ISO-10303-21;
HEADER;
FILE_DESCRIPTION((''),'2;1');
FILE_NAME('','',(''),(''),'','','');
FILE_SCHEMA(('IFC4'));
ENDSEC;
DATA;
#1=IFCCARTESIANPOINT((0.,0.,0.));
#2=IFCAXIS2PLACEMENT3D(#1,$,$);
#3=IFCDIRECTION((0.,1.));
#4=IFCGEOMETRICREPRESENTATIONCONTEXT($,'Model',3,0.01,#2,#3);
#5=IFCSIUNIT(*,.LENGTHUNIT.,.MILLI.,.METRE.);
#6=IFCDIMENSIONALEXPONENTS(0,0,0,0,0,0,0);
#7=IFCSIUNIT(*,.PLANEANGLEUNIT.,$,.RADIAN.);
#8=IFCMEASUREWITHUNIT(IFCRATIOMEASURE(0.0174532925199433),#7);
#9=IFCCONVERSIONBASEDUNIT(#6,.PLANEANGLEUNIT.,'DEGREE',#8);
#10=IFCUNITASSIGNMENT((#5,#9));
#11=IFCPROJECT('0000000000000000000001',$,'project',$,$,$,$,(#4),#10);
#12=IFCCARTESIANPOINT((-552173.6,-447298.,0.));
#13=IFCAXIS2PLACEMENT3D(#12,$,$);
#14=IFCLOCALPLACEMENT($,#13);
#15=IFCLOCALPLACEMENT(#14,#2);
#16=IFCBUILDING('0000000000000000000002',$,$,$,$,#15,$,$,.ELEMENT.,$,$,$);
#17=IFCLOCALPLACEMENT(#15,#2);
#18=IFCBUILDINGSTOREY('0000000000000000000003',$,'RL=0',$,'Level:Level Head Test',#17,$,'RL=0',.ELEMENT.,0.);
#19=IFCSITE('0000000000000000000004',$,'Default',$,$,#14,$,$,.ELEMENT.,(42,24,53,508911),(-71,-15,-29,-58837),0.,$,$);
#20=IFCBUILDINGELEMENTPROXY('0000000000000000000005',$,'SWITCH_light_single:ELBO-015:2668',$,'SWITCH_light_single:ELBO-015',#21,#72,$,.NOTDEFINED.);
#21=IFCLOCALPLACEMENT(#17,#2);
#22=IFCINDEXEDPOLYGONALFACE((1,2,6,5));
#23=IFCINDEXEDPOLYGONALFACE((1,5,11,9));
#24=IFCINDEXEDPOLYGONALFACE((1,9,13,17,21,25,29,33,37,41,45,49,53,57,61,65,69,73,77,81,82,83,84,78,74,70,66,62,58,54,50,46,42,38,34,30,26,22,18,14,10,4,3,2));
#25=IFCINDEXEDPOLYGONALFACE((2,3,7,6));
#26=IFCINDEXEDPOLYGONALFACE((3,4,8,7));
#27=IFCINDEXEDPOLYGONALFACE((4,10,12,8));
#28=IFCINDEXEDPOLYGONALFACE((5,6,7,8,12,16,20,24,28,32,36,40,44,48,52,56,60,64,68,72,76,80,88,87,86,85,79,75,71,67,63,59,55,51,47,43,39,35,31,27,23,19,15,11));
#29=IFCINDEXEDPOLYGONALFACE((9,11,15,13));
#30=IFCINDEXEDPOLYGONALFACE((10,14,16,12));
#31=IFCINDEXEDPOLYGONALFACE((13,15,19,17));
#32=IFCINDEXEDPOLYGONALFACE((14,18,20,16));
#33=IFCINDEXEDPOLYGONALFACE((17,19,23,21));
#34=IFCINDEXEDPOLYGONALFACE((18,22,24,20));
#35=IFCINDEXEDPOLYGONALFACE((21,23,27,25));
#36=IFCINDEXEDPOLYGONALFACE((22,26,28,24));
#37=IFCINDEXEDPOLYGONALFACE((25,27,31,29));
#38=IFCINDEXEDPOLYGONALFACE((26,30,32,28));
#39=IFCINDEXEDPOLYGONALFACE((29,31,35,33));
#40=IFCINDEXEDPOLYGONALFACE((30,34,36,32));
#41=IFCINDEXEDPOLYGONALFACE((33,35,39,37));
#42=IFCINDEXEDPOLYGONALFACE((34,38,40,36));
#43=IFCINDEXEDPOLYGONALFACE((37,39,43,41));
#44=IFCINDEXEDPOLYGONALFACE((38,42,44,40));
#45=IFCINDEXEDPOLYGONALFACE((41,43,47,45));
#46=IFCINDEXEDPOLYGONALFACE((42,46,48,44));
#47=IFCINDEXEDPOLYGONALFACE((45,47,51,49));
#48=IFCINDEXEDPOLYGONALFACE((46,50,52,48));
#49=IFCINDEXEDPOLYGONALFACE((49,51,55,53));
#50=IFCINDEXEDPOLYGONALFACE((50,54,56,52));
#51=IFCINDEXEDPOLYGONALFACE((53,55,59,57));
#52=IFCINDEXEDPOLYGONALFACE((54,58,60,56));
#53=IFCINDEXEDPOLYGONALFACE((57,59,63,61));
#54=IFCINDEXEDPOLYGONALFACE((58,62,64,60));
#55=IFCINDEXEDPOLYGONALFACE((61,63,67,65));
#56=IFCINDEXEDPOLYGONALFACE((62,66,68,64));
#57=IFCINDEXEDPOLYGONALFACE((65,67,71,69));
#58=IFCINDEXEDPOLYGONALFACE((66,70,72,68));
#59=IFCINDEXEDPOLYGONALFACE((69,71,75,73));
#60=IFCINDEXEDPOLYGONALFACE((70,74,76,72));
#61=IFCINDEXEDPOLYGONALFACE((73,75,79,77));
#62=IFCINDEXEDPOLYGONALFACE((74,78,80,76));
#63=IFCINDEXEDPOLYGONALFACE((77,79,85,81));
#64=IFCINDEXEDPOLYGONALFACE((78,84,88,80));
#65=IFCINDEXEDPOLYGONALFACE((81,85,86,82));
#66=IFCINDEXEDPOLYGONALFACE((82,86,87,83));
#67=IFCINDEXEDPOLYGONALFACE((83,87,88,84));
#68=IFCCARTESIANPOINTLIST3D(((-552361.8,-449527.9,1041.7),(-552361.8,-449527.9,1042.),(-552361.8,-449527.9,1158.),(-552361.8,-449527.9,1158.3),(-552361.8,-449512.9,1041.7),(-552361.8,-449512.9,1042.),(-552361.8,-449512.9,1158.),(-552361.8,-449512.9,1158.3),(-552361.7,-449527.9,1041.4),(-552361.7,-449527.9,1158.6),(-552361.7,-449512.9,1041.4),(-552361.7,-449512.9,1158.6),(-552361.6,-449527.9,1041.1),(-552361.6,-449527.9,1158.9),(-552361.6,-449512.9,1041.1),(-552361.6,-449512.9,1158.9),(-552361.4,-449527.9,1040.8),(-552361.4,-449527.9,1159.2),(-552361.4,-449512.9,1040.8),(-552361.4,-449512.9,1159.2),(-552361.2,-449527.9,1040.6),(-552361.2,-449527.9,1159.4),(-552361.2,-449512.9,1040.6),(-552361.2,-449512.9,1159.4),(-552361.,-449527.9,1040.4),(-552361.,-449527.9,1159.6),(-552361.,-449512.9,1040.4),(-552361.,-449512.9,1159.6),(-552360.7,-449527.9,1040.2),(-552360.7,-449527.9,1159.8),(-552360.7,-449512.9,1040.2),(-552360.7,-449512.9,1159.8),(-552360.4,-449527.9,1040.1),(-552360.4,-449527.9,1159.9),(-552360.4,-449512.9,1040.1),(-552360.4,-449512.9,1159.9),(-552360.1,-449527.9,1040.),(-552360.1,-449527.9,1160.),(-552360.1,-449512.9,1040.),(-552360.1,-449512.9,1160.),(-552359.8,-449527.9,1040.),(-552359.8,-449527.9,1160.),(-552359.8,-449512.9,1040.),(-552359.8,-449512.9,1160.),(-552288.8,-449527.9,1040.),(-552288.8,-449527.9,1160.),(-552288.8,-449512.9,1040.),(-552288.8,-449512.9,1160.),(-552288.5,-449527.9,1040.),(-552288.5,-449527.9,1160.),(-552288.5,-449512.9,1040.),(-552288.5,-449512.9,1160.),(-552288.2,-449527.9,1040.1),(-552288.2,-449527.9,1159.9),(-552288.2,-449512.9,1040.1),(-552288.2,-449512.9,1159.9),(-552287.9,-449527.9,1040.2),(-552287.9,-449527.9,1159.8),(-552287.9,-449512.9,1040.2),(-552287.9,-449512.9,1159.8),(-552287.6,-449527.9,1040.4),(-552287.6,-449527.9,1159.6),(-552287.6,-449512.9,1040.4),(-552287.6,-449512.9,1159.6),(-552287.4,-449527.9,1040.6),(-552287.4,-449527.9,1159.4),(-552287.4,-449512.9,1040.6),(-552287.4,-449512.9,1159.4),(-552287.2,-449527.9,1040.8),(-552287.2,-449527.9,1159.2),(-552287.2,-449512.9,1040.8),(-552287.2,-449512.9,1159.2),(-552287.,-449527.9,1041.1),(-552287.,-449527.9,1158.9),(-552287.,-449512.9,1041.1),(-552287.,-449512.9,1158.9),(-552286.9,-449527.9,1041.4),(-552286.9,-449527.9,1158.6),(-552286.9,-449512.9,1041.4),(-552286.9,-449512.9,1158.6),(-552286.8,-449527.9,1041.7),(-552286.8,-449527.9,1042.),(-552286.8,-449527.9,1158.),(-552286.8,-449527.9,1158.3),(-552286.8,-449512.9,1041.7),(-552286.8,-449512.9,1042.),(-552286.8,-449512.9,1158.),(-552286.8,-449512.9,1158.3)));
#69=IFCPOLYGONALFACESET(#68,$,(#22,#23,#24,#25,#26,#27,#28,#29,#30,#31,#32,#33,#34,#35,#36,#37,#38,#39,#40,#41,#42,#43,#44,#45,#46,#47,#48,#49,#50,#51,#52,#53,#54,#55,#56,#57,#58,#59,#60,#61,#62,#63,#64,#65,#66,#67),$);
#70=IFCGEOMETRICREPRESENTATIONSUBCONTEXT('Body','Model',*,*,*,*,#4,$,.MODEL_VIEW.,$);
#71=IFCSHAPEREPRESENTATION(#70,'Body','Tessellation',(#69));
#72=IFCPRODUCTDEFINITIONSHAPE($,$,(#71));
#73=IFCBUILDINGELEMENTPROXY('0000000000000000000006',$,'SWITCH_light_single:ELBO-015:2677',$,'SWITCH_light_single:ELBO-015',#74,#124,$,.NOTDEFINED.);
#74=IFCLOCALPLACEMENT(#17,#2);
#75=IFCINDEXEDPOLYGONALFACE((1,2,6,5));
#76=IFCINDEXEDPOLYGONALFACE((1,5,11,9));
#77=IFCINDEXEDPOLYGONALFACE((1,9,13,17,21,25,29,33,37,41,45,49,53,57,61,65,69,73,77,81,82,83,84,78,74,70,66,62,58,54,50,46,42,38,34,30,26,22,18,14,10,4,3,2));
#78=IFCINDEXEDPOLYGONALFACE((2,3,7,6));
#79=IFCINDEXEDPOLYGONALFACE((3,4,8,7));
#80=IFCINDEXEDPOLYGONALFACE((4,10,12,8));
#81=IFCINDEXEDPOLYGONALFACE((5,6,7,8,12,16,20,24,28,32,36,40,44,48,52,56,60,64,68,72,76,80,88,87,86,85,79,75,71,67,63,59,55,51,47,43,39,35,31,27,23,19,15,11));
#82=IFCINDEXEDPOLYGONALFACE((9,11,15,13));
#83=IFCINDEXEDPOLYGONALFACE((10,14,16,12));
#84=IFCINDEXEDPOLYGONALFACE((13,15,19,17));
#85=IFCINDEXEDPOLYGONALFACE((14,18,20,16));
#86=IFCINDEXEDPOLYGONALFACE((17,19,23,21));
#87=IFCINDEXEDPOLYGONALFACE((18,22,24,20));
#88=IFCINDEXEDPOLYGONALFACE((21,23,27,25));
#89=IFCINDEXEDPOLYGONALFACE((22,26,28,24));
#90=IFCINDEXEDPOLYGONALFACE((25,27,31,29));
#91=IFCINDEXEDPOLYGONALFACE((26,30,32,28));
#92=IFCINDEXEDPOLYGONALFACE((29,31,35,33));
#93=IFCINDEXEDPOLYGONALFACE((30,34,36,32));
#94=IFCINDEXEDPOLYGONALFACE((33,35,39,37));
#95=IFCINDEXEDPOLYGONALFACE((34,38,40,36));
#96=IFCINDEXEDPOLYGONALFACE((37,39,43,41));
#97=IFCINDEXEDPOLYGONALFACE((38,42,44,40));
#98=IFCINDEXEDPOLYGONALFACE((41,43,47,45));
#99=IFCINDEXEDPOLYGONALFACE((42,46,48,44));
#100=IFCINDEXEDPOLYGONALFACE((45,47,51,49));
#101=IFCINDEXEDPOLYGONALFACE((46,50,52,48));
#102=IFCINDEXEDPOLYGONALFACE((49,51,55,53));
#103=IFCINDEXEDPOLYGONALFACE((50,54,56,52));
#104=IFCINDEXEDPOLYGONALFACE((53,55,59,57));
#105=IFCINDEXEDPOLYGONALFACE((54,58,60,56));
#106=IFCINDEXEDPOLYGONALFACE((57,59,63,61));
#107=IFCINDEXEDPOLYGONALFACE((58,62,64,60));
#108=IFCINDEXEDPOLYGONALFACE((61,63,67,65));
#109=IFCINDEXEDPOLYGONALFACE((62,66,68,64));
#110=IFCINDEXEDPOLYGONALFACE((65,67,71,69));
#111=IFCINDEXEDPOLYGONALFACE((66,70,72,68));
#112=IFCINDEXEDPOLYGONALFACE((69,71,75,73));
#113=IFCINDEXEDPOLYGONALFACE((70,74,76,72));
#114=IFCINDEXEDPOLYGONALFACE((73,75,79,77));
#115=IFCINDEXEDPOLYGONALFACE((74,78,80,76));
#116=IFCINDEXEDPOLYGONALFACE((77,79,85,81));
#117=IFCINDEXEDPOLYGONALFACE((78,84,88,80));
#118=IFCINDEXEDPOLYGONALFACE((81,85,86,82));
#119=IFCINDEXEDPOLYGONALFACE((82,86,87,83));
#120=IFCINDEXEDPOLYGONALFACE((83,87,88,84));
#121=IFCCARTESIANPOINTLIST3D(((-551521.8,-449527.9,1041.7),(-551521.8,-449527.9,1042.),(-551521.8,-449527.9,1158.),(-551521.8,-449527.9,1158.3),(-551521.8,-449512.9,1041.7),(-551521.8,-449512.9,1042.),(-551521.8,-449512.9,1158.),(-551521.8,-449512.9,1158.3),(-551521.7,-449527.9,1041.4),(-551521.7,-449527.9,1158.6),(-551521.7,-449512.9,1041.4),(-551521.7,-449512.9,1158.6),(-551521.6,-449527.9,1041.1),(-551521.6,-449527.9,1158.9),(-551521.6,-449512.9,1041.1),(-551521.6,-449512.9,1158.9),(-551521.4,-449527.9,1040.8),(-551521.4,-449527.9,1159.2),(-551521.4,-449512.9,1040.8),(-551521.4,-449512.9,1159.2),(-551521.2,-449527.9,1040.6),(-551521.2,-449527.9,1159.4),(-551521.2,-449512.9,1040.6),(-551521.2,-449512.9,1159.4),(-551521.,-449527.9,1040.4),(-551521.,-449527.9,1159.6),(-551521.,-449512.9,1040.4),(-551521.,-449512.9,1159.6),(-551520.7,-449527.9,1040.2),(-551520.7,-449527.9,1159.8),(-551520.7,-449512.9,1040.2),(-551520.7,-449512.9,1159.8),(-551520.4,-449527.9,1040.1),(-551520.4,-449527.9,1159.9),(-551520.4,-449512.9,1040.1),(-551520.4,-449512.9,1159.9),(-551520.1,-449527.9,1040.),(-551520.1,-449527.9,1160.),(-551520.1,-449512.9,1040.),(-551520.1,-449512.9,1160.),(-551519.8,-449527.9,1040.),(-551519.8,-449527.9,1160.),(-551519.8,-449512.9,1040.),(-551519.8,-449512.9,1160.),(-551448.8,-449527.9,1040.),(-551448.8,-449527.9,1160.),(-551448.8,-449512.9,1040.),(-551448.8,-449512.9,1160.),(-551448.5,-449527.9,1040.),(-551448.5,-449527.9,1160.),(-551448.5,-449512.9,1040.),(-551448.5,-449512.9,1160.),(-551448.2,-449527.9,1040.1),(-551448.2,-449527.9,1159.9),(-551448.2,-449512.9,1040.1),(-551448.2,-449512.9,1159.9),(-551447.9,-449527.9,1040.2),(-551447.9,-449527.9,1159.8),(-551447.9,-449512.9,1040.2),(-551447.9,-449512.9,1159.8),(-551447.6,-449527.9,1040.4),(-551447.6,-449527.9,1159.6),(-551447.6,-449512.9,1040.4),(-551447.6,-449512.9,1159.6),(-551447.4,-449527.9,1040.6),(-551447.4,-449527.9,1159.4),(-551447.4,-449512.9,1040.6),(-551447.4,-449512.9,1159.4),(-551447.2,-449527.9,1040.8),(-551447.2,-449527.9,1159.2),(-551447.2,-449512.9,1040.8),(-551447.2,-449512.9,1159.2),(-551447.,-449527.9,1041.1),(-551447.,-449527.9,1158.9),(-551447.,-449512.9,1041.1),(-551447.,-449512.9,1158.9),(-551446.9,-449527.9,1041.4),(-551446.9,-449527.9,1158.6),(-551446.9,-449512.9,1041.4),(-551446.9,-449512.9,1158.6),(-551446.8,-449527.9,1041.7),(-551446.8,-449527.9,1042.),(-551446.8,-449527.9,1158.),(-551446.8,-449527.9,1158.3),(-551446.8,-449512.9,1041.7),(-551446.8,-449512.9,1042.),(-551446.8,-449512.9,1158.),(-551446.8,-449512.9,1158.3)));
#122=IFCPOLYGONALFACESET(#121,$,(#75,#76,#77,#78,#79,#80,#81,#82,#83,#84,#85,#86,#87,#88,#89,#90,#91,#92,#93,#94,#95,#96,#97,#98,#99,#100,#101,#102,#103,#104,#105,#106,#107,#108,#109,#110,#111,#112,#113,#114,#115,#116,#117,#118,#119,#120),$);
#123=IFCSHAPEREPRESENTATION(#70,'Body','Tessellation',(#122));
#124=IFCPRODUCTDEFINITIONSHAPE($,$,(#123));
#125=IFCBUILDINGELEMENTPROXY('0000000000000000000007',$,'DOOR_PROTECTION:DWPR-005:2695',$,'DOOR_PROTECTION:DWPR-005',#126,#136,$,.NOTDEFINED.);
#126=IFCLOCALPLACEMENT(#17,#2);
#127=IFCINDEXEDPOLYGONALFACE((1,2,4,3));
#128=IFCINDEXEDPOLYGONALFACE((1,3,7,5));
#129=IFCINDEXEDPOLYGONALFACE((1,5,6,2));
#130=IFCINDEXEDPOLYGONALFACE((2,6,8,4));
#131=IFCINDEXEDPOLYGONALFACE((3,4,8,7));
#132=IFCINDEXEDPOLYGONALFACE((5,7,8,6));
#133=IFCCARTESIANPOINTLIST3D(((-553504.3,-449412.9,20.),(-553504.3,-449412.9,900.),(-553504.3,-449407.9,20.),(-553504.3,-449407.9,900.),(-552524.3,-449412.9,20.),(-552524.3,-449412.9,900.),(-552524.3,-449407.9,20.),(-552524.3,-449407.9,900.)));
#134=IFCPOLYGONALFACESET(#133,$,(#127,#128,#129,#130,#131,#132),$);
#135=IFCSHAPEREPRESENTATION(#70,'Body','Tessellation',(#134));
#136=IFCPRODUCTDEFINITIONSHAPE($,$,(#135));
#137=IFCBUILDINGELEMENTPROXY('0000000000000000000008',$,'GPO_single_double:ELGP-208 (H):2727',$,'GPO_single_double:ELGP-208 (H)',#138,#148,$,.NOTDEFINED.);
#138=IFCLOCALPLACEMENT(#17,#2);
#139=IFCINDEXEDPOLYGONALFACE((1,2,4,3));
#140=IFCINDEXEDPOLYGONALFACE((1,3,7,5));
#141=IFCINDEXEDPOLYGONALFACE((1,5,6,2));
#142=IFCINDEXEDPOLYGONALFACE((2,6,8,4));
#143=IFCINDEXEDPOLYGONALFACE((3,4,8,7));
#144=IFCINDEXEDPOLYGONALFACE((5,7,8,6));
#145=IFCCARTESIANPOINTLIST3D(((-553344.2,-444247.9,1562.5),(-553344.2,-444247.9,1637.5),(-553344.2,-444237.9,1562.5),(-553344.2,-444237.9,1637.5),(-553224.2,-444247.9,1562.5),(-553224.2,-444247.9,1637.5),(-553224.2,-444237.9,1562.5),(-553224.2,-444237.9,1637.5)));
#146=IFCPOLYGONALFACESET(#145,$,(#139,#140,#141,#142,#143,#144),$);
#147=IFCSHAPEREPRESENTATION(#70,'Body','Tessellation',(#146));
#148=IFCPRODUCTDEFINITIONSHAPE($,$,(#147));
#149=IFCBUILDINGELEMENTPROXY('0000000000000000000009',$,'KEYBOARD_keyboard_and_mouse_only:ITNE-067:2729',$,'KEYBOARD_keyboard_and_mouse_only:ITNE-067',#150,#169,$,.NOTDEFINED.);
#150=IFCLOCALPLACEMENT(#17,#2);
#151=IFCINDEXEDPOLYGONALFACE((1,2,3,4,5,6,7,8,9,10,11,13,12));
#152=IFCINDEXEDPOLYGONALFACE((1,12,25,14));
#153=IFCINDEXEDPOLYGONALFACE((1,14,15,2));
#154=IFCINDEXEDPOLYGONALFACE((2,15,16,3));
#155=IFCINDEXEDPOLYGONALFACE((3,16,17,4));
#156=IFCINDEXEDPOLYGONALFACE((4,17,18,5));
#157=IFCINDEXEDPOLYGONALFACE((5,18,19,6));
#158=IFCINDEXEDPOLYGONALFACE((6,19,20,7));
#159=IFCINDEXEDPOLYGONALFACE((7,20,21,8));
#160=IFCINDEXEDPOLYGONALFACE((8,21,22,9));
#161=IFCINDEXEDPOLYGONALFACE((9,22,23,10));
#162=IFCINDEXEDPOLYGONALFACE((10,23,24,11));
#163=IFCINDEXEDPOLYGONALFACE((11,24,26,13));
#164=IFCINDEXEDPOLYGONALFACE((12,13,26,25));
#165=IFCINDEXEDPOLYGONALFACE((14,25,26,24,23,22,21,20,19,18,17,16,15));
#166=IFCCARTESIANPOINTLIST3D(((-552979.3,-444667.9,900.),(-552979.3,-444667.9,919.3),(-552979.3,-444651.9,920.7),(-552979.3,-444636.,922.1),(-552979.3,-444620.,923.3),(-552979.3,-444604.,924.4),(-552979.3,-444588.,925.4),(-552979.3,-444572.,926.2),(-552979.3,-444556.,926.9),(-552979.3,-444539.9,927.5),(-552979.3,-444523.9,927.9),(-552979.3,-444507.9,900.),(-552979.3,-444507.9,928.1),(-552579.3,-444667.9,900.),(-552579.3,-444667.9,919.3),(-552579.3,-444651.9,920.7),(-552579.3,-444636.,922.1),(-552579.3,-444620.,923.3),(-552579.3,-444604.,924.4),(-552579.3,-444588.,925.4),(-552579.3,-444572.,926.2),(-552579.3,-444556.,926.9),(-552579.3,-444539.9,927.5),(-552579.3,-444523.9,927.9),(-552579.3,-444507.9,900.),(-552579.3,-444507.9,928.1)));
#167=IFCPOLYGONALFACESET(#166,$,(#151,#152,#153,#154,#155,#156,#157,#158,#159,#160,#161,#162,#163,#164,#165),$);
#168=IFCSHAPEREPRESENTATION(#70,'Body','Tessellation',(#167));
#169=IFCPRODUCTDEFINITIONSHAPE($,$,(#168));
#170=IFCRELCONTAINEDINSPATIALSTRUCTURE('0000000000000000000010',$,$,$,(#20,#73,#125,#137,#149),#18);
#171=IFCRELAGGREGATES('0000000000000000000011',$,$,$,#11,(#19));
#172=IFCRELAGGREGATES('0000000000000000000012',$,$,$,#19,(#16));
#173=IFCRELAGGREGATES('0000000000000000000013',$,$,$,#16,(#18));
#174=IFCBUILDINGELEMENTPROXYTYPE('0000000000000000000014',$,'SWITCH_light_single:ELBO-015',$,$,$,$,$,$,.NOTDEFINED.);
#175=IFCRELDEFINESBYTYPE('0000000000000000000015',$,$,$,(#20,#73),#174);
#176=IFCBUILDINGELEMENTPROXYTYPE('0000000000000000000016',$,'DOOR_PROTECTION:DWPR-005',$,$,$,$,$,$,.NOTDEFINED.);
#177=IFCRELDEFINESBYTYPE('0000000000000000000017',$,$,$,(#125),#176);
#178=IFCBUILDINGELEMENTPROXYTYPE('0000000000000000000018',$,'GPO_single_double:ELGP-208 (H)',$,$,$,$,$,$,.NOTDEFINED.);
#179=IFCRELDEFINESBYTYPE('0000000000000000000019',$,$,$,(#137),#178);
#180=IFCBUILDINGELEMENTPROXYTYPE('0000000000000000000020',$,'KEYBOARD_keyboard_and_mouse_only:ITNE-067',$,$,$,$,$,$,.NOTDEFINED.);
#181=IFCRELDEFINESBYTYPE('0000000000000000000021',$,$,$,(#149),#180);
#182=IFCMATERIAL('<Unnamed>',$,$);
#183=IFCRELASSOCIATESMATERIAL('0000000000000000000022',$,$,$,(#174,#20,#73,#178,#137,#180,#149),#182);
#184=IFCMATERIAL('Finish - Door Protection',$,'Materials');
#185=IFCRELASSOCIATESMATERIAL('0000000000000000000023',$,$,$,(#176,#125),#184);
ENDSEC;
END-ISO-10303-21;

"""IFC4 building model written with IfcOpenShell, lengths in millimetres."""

from ifc_helpers import new_model, entity, si_unit, converted_unit, direction, frame, origin, place, context, subcontext, project, spatial, indexed_curve, outline, extrude, source, transform, mapped, material, type_object, type_shapes, element, save


model = new_model("IFC4")

# Units and contexts
model_context = context("Model", 3, precision=0.01, world=origin(), true_north=direction((0.0, 1.0)))
body_context = subcontext(model_context, "Body", "Model", "MODEL_VIEW")
ifc_project = project(units=[si_unit("LENGTHUNIT", "METRE", prefix="MILLI"), converted_unit("PLANEANGLEUNIT", "DEGREE", entity("IfcRatioMeasure", 0.0174532925199433), si_unit("PLANEANGLEUNIT", "RADIAN"), dimensions=[0, 0, 0, 0, 0, 0, 0])], contexts=[model_context])

# Site, building, storey
site_placement = place(None, frame((-552173.6, -447298.0, 0.0)))
site = spatial("IfcSite", under=ifc_project, at=site_placement, Name="Default", CompositionType="ELEMENT", RefLatitude=(42, 24, 53, 508911), RefLongitude=(-71, -15, -29, -58837), RefElevation=0.0)
building_placement = place(site_placement, origin())
building = spatial("IfcBuilding", under=site, at=building_placement, CompositionType="ELEMENT")
storey_placement = place(building_placement, origin())
storey = spatial("IfcBuildingStorey", under=building, at=storey_placement, Name="RL=0", ObjectType="Level:Level Head Test", LongName="RL=0", CompositionType="ELEMENT", Elevation=0.0)

# Shared definitions
ifc_material_1 = material(Name="<Unnamed>")

# Building element proxies
building_element_proxy_type_1 = type_object("IfcBuildingElementProxyType", Name="SWITCH_light_single:ELBO-015", PredefinedType="NOTDEFINED", material=ifc_material_1)
shared_shape_1 = source(origin(), body_context, "Body", "SweptSolid", [
    extrude(outline(indexed_curve([(-35.5, -60.0), (35.5, -60.0), (35.8, -60.0), (36.1, -59.9), (36.4, -59.8), (36.7, -59.6), (36.9, -59.4), (37.1, -59.2), (37.3, -58.9), (37.4, -58.6), (37.5, -58.3), (37.5, -58.0), (37.5, 58.0), (37.5, 58.3), (37.4, 58.6), (37.3, 58.9), (37.1, 59.2), (36.9, 59.4), (36.7, 59.6), (36.4, 59.8), (36.1, 59.9), (35.8, 60.0), (35.5, 60.0), (-35.5, 60.0), (-35.8, 60.0), (-36.1, 59.9), (-36.4, 59.8), (-36.7, 59.6), (-36.9, 59.4), (-37.1, 59.2), (-37.3, 58.9), (-37.4, 58.6), (-37.5, 58.3), (-37.5, 58.0), (-37.5, -58.0), (-37.5, -58.3), (-37.4, -58.6), (-37.3, -58.9), (-37.1, -59.2), (-36.9, -59.4), (-36.7, -59.6), (-36.4, -59.8), (-36.1, -59.9), (-35.8, -60.0), (-35.5, -60.0)], self_intersect=False)), frame((0.0, -15.0, 0.0), z_axis=(0.0, 1.0, 0.0), x_axis=(1.0, 0.0, 0.0)), (0.0, 0.0, 1.0), 15.0),
])
type_shapes(building_element_proxy_type_1, [shared_shape_1])
for number, where, z_axis, x_axis, name in (
    (1, (-552324.3, -449527.9, 1100.0), (0.0, 0.0, 1.0), (-1.0, 0.0, 0.0), "SWITCH_light_single:ELBO-015:2668"),
    (2, (-551484.3, -449527.9, 1100.0), (0.0, 0.0, 1.0), (-1.0, 0.0, 0.0), "SWITCH_light_single:ELBO-015:2677"),
):
    element("IfcBuildingElementProxy", number, at=place(storey_placement, frame(where, z_axis=z_axis, x_axis=x_axis)), inside=storey, type_object=building_element_proxy_type_1, material=ifc_material_1, Name=name, ObjectType="SWITCH_light_single:ELBO-015", PredefinedType="NOTDEFINED", context=body_context, shape_type="MappedRepresentation", body=[
        mapped(shared_shape_1, transform((0.0, 0.0, 0.0), scale=1.0)),
    ])
ifc_material_2 = material(Name="Finish - Door Protection", Category="Materials")
building_element_proxy_type_2 = type_object("IfcBuildingElementProxyType", Name="DOOR_PROTECTION:DWPR-005", PredefinedType="NOTDEFINED", material=ifc_material_2)
shared_shape_2 = source(origin(), body_context, "Body", "SweptSolid", [
    extrude(outline(indexed_curve([(-490.0, -2.5), (490.0, -2.5), (490.0, 2.5), (-490.0, 2.5), (-490.0, -2.5)], self_intersect=False)), frame((490.0, 2.5, 0.0), z_axis=(0.0, 0.0, 1.0), x_axis=(-1.0, 0.0, 0.0)), (0.0, 0.0, 1.0), 880.0),
])
type_shapes(building_element_proxy_type_2, [shared_shape_2])
proxy_1_placement = place(storey_placement, frame((-553504.3, -449412.9, 20.0)))
element("IfcBuildingElementProxy", 3, at=proxy_1_placement, inside=storey, type_object=building_element_proxy_type_2, material=ifc_material_2, Name="DOOR_PROTECTION:DWPR-005:2695", ObjectType="DOOR_PROTECTION:DWPR-005", PredefinedType="NOTDEFINED", context=body_context, shape_type="MappedRepresentation", body=[
    mapped(shared_shape_2, transform((0.0, 0.0, 0.0), scale=1.0)),
])
building_element_proxy_type_3 = type_object("IfcBuildingElementProxyType", Name="GPO_single_double:ELGP-208 (H)", PredefinedType="NOTDEFINED", material=ifc_material_1)
shared_shape_3 = source(origin(), body_context, "Body", "SweptSolid", [
    extrude(outline(indexed_curve([(-60.0, -5.0), (60.0, -5.0), (60.0, 5.0), (-60.0, 5.0), (-60.0, -5.0)], self_intersect=False)), frame((60.0, 5.0, 0.0), z_axis=(0.0, 0.0, 1.0), x_axis=(-1.0, 0.0, 0.0)), (0.0, 0.0, 1.0), 75.0),
])
type_shapes(building_element_proxy_type_3, [shared_shape_3])
proxy_2_placement = place(storey_placement, frame((-553224.2, -444237.9, 1562.5), z_axis=(0.0, 0.0, 1.0), x_axis=(-1.0, 0.0, 0.0)))
element("IfcBuildingElementProxy", 4, at=proxy_2_placement, inside=storey, type_object=building_element_proxy_type_3, material=ifc_material_1, Name="GPO_single_double:ELGP-208 (H):2727", ObjectType="GPO_single_double:ELGP-208 (H)", PredefinedType="NOTDEFINED", context=body_context, shape_type="MappedRepresentation", body=[
    mapped(shared_shape_3, transform((0.0, 0.0, 0.0), scale=1.0)),
])
building_element_proxy_type_4 = type_object("IfcBuildingElementProxyType", Name="KEYBOARD_keyboard_and_mouse_only:ITNE-067", PredefinedType="NOTDEFINED", material=ifc_material_1)
shared_shape_4 = source(origin(), body_context, "Body", "SweptSolid", [
    extrude(outline(indexed_curve([(-11.8, -80.0), (7.4, -80.0), (8.9, -64.0), (10.3, -48.1), (11.5, -32.1), (12.6, -16.1), (13.5, -0.1), (14.4, 15.9), (15.1, 31.9), (15.6, 47.9), (16.0, 64.0), (16.3, 80.0), (-11.8, 80.0), (-11.8, -80.0)], self_intersect=False)), frame((-400.0, -80.0, 11.8), z_axis=(1.0, 0.0, 0.0), x_axis=(0.0, 0.0, 1.0)), (0.0, 0.0, 1.0), 400.0),
])
type_shapes(building_element_proxy_type_4, [shared_shape_4])
proxy_3_placement = place(storey_placement, frame((-552979.3, -444667.9, 900.0), z_axis=(0.0, 0.0, 1.0), x_axis=(-1.0, 0.0, 0.0)))
element("IfcBuildingElementProxy", 5, at=proxy_3_placement, inside=storey, type_object=building_element_proxy_type_4, material=ifc_material_1, Name="KEYBOARD_keyboard_and_mouse_only:ITNE-067:2729", ObjectType="KEYBOARD_keyboard_and_mouse_only:ITNE-067", PredefinedType="NOTDEFINED", context=body_context, shape_type="MappedRepresentation", body=[
    mapped(shared_shape_4, transform((0.0, 0.0, 0.0), scale=1.0)),
])

save(model, "model.ifc")
